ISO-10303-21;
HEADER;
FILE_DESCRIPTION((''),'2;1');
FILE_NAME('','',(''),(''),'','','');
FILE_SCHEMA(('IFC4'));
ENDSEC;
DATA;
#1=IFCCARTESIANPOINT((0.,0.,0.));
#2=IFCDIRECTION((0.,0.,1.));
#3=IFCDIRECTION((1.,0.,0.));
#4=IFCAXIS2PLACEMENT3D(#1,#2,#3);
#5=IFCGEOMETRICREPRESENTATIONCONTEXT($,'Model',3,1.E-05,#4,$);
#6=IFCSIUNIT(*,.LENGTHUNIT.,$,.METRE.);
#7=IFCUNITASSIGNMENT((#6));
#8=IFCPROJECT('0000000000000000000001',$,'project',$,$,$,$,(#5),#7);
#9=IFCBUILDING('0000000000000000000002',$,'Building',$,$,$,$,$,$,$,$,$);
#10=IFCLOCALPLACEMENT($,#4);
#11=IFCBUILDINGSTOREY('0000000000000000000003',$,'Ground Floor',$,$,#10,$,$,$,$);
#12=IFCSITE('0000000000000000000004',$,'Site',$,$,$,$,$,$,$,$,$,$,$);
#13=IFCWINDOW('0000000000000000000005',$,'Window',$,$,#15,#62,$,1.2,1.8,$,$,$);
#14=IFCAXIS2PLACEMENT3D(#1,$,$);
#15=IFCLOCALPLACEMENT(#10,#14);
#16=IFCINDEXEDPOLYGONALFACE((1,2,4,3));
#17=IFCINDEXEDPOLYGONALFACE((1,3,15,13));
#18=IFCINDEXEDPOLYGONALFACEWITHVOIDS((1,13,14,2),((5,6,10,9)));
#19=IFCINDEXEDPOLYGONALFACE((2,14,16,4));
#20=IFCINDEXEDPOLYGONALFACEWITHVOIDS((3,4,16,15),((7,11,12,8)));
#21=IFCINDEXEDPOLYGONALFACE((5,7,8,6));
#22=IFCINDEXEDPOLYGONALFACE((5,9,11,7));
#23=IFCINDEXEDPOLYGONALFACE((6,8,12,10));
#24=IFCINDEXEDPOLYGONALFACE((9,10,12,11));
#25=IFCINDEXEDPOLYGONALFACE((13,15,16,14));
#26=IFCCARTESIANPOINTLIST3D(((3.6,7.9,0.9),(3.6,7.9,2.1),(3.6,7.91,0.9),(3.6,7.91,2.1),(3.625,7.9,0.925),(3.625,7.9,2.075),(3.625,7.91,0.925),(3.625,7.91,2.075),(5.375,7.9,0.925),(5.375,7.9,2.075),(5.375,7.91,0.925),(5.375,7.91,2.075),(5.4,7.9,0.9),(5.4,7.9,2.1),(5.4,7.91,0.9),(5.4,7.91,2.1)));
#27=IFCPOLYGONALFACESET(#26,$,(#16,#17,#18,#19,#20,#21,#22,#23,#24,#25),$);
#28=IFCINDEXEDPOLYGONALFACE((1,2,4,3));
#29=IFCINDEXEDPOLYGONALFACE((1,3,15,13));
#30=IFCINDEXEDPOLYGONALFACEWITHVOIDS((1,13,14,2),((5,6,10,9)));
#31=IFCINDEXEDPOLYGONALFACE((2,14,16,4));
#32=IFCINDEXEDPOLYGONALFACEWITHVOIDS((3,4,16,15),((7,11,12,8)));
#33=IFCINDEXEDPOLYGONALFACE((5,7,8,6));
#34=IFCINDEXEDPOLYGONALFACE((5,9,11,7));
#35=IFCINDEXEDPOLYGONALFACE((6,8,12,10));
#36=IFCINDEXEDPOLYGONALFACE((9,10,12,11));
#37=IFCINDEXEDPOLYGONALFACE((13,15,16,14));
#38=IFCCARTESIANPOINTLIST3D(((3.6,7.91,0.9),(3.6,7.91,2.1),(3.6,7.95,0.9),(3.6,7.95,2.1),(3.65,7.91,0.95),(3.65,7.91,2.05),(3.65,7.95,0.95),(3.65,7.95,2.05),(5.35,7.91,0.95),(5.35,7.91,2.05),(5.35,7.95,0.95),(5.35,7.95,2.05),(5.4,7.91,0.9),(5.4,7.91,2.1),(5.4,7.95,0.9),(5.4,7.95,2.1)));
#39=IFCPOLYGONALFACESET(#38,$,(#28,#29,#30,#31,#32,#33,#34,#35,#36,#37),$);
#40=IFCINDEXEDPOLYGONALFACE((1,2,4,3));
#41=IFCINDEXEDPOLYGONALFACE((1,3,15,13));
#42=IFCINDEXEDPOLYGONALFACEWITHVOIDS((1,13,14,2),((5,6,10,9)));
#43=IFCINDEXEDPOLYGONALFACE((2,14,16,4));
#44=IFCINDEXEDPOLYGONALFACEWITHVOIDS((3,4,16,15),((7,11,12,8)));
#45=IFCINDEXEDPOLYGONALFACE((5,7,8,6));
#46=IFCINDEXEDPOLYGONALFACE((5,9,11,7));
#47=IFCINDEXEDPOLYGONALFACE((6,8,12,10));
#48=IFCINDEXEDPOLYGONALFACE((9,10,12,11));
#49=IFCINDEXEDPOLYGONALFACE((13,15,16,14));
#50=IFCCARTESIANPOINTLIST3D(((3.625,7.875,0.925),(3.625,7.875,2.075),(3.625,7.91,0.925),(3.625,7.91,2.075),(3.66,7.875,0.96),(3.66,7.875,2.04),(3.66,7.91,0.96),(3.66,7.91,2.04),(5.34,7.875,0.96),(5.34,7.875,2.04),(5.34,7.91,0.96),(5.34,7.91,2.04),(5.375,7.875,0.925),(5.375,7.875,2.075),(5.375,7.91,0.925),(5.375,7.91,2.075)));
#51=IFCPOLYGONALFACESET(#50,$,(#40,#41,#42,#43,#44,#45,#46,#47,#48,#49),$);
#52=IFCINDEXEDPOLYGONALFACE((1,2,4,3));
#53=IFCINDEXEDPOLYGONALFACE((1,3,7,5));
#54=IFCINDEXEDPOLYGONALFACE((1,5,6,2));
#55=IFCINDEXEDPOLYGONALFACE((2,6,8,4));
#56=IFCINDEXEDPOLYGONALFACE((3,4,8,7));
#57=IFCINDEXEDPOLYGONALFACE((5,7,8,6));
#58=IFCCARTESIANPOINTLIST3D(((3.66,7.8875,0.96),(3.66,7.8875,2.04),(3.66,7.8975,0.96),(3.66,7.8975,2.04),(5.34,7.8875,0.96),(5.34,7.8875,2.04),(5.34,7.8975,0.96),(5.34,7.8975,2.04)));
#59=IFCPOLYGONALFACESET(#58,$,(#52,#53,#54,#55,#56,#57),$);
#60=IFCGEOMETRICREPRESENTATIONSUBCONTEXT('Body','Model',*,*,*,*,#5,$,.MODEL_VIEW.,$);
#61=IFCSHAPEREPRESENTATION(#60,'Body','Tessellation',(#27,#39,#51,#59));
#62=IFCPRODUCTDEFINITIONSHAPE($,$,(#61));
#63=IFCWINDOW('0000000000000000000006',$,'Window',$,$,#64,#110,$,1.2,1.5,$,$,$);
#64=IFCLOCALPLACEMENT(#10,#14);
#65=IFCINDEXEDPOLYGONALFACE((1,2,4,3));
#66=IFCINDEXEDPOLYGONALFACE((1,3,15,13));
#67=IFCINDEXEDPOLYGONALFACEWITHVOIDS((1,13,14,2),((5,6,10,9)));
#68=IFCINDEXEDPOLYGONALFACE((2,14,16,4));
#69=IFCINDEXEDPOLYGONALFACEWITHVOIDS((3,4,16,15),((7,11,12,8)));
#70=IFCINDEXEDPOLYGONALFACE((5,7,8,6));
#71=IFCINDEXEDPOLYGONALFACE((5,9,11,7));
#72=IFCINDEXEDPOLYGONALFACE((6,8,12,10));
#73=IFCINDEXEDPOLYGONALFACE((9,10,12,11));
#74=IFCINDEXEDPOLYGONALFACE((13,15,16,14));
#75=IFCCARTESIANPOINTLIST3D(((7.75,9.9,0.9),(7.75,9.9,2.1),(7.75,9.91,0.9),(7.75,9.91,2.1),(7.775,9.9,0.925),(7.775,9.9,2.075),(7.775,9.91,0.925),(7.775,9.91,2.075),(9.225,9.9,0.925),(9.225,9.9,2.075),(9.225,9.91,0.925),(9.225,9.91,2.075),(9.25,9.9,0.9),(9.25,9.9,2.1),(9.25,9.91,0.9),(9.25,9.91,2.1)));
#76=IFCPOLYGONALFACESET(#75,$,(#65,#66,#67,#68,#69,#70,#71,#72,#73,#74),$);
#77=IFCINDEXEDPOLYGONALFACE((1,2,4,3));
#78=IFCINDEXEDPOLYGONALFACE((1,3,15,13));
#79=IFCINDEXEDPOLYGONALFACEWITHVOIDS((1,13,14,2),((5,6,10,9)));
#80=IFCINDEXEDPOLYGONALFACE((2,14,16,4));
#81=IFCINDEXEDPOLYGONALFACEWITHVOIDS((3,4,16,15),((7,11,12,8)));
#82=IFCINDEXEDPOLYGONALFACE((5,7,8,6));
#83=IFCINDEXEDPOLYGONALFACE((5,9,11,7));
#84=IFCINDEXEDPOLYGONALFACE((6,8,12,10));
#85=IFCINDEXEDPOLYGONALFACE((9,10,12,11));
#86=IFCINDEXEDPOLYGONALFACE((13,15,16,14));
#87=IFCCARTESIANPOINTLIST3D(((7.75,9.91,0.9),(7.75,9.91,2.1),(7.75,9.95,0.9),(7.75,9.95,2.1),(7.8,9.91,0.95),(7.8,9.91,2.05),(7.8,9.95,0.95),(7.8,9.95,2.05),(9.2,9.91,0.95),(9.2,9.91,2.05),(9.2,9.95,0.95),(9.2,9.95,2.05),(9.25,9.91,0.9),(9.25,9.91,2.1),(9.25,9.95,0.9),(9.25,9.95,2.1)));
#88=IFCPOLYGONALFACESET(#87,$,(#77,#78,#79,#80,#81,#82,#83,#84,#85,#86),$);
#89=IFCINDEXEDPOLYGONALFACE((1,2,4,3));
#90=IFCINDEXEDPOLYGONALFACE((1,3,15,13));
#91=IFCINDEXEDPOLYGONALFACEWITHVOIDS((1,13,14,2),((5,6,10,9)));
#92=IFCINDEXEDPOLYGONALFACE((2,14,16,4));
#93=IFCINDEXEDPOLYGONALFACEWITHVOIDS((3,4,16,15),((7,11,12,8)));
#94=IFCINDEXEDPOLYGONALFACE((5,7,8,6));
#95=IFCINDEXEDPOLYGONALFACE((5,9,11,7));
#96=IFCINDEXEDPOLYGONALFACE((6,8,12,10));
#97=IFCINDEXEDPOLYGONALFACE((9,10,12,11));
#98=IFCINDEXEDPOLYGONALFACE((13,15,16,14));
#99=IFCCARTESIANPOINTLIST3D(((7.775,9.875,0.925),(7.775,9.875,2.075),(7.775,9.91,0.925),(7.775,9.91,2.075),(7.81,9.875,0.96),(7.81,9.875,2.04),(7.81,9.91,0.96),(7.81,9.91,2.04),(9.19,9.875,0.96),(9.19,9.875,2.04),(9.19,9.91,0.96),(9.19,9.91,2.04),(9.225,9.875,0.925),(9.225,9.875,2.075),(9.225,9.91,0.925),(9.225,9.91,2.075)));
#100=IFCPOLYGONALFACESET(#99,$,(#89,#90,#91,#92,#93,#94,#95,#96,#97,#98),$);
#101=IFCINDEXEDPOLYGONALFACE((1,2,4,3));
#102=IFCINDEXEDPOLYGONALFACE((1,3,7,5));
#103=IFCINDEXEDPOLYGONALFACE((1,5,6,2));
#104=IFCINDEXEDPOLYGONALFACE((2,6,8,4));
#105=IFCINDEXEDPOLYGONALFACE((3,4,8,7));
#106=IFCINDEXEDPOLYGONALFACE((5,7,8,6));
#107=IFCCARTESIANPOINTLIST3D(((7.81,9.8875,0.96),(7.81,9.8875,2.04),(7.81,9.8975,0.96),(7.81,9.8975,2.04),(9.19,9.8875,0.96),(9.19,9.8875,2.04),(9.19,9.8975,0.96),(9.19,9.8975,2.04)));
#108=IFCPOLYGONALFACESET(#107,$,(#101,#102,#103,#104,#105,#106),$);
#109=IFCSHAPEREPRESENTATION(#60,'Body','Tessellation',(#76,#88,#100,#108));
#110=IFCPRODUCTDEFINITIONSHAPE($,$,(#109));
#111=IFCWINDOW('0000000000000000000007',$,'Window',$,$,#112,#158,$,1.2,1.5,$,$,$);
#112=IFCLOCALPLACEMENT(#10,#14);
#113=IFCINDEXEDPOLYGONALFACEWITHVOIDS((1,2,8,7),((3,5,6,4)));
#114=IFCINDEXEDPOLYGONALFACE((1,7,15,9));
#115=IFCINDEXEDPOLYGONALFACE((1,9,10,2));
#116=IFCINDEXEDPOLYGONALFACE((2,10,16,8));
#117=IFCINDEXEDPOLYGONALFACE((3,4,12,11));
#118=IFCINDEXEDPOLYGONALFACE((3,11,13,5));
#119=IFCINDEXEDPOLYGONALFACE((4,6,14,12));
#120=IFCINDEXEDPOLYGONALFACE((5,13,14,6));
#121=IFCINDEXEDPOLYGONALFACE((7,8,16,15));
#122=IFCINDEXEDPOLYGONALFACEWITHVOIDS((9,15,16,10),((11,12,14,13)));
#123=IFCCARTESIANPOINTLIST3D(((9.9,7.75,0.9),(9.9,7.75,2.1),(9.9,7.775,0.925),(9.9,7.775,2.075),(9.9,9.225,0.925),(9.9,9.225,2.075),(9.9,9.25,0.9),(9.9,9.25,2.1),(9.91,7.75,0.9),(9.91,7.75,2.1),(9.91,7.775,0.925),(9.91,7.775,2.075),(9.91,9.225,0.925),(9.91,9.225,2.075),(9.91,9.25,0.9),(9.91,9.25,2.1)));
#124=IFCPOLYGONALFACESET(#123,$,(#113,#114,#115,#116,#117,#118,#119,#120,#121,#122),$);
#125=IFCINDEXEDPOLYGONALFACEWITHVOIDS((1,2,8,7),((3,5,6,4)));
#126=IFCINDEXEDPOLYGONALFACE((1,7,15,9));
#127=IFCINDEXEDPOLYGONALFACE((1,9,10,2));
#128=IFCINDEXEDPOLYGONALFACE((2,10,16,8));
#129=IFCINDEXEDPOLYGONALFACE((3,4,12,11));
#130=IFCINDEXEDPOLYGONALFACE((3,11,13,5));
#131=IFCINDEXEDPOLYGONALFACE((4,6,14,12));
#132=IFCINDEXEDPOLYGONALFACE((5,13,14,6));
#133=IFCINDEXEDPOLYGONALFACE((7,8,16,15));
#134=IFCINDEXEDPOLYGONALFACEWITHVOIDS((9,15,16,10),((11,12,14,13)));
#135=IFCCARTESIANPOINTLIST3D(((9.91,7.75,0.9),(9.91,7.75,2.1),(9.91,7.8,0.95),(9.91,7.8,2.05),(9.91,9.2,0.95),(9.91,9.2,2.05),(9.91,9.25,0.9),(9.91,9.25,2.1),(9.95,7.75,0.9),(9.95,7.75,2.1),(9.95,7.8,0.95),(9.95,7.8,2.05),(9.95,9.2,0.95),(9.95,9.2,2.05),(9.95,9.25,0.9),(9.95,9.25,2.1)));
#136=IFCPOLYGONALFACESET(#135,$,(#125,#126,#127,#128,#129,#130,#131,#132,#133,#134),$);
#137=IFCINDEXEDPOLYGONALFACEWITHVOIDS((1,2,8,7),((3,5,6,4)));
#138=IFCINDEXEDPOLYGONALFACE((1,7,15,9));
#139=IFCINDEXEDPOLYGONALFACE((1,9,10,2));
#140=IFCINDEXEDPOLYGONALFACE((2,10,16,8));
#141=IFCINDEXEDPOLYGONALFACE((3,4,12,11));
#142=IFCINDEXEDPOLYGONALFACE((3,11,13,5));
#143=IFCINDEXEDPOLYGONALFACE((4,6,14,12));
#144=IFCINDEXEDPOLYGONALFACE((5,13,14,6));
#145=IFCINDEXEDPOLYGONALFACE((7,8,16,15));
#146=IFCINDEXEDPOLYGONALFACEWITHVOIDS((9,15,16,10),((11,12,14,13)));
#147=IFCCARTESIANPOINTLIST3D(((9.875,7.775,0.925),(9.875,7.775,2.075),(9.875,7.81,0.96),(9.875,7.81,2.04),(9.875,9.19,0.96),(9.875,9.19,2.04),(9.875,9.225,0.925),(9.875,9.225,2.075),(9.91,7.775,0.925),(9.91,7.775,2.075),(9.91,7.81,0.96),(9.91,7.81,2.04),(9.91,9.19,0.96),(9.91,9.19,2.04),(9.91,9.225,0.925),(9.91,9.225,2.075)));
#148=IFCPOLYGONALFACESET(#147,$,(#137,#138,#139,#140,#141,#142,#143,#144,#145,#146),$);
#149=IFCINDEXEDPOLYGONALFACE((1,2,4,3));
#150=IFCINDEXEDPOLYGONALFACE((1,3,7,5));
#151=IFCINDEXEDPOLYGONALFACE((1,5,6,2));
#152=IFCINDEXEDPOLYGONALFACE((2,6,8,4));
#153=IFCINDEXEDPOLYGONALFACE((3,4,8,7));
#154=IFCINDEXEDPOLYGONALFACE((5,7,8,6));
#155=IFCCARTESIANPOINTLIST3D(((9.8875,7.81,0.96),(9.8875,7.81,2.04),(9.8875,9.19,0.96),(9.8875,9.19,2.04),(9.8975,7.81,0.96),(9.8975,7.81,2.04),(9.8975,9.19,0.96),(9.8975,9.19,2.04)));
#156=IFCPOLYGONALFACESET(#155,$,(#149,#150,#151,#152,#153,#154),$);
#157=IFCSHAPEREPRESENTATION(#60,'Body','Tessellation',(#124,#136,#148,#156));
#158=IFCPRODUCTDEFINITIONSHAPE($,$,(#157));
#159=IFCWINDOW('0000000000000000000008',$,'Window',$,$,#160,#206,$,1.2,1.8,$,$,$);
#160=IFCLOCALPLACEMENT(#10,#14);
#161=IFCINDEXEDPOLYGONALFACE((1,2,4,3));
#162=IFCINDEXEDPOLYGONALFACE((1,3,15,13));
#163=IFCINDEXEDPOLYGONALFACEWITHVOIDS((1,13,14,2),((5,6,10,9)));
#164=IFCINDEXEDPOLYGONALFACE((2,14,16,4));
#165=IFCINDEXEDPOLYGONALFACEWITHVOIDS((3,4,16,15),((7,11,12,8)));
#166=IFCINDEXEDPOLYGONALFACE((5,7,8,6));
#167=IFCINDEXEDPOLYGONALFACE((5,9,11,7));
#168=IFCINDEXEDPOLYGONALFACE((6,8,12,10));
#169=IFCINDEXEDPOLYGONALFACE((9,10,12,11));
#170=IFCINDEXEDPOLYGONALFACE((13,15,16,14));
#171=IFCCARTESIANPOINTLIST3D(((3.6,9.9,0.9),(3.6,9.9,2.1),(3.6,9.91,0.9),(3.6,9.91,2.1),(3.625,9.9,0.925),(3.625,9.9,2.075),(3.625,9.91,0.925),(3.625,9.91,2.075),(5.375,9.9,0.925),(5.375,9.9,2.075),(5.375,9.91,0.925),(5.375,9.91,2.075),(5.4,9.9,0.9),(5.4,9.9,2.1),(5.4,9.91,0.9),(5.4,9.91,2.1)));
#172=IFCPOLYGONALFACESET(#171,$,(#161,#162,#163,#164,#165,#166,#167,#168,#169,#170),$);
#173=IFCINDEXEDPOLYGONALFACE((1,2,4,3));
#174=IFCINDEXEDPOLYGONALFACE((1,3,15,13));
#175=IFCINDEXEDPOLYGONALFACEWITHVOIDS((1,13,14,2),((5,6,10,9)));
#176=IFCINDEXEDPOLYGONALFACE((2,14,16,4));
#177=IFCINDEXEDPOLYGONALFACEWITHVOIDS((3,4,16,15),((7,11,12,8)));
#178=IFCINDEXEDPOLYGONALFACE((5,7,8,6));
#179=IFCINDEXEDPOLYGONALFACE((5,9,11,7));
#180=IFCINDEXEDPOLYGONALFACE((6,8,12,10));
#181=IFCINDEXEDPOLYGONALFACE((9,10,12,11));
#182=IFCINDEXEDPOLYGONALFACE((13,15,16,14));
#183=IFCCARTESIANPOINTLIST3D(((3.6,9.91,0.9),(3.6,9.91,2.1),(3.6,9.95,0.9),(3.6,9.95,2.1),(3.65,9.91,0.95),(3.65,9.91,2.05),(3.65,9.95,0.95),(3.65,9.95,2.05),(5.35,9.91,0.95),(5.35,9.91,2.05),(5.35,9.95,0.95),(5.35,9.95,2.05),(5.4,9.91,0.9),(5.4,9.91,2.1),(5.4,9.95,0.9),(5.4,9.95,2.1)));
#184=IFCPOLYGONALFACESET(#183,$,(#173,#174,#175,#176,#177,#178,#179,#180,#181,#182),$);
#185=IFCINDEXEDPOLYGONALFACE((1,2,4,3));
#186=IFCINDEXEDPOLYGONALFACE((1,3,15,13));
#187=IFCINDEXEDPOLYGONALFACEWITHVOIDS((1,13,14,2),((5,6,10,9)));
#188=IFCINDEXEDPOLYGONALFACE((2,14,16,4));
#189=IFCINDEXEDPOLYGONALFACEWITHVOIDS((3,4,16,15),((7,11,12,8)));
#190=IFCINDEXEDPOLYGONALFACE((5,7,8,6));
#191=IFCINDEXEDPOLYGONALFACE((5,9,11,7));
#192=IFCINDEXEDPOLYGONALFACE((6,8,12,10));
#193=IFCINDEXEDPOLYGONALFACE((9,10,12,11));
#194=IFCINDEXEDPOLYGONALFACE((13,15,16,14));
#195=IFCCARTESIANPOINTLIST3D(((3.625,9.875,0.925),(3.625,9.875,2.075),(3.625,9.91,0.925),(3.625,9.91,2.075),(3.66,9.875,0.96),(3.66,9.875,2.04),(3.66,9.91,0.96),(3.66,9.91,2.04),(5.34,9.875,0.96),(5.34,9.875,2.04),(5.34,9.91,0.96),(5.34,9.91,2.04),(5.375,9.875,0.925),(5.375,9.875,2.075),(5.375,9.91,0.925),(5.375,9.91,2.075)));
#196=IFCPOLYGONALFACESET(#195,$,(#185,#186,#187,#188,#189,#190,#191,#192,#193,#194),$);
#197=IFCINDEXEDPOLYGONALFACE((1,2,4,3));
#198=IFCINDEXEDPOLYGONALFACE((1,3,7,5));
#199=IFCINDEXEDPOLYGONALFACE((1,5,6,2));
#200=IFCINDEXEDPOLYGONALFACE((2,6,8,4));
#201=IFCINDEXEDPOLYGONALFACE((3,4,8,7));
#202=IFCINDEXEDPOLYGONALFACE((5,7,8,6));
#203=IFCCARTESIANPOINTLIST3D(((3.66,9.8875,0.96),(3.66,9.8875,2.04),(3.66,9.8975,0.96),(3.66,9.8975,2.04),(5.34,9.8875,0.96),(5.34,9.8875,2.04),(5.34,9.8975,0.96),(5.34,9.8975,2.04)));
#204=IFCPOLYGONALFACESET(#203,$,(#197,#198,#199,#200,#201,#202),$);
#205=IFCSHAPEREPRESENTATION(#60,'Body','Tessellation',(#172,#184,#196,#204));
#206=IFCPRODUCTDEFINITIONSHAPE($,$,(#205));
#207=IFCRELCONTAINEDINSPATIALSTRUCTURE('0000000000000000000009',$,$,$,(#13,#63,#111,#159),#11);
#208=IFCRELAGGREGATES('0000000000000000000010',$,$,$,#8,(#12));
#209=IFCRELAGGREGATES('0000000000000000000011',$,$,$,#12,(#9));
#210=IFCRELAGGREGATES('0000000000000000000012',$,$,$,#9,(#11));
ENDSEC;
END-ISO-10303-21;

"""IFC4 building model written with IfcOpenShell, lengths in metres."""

from ifc_helpers import new_model, si_unit, frame, origin_with_axes, place, context, subcontext, project, spatial, line, indexed_curve, outline, extrude, element, save


model = new_model("IFC4")

# Units and contexts
model_context = context("Model", 3, precision=1e-05, world=origin_with_axes())
body_context = subcontext(model_context, "Body", "Model", "MODEL_VIEW")
ifc_project = project(units=[si_unit("LENGTHUNIT", "METRE")], contexts=[model_context])

# Site, building, storey
site = spatial("IfcSite", under=ifc_project, Name="Site")
building = spatial("IfcBuilding", under=site, Name="Building")
storey_placement = place(None, origin_with_axes())
storey = spatial("IfcBuildingStorey", under=building, at=storey_placement, Name="Ground Floor")

# Windows
window_1_placement = place(storey_placement, frame((5.4, 8.0, 0.9), z_axis=(0.0, 0.0, 1.0), x_axis=(-1.0, 0.0, 0.0)))
element("IfcWindow", 1, at=window_1_placement, inside=storey, Name="Window", OverallHeight=1.2, OverallWidth=1.8, context=body_context, shape_type="SweptSolid", body=[
    extrude(outline(indexed_curve([(0.0, 0.0), (1.8, 0.0), (1.8, 1.2), (0.0, 1.2)], segments=[line(1, 2, 3, 4, 1)]), holes=[indexed_curve([(0.025, 0.025), (1.775, 0.025), (1.775, 1.175), (0.025, 1.175)], segments=[line(1, 2, 3, 4, 1)])]), frame((0.0, 0.09, 0.0), z_axis=(0.0, -1.0, 0.0), x_axis=(1.0, 0.0, 0.0)), (0.0, 0.0, -1.0), 0.01),
    extrude(outline(indexed_curve([(0.0, 0.0), (1.8, 0.0), (1.8, 1.2), (0.0, 1.2)], segments=[line(1, 2, 3, 4, 1)]), holes=[indexed_curve([(0.05, 0.05), (1.75, 0.05), (1.75, 1.15), (0.05, 1.15)], segments=[line(1, 2, 3, 4, 1)])]), frame((0.0, 0.05, 0.0), z_axis=(0.0, -1.0, 0.0), x_axis=(1.0, 0.0, 0.0)), (0.0, 0.0, -1.0), 0.04),
    extrude(outline(indexed_curve([(0.0, 0.0), (1.75, 0.0), (1.75, 1.15), (0.0, 1.15)], segments=[line(1, 2, 3, 4, 1)]), holes=[indexed_curve([(0.035, 0.035), (1.715, 0.035), (1.715, 1.115), (0.035, 1.115)], segments=[line(1, 2, 3, 4, 1)])]), frame((0.025, 0.09, 0.025), z_axis=(0.0, -1.0, 0.0), x_axis=(1.0, 0.0, 0.0)), (0.0, 0.0, -1.0), 0.035),
    extrude(outline(indexed_curve([(0.035, 0.035), (1.715, 0.035), (1.715, 1.115), (0.035, 1.115)], segments=[line(1, 2, 3, 4, 1)])), frame((0.025, 0.1025, 0.025), z_axis=(0.0, -1.0, 0.0), x_axis=(1.0, 0.0, 0.0)), (0.0, 0.0, -1.0), 0.01),
])
for number, where, z_axis, x_axis, name in (
    (2, (9.25, 10.0, 0.9), (0.0, 0.0, 1.0), (-1.0, 0.0, 0.0), "Window"),
    (3, (10.0, 7.75, 0.9), (0.0, 0.0, 1.0), (0.0, 1.0, 0.0), "Window"),
):
    element("IfcWindow", number, at=place(storey_placement, frame(where, z_axis=z_axis, x_axis=x_axis)), inside=storey, Name=name, OverallHeight=1.2, OverallWidth=1.5, context=body_context, shape_type="SweptSolid", body=[
        extrude(outline(indexed_curve([(0.0, 0.0), (1.5, 0.0), (1.5, 1.2), (0.0, 1.2)], segments=[line(1, 2, 3, 4, 1)]), holes=[indexed_curve([(0.025, 0.025), (1.475, 0.025), (1.475, 1.175), (0.025, 1.175)], segments=[line(1, 2, 3, 4, 1)])]), frame((0.0, 0.09, 0.0), z_axis=(0.0, -1.0, 0.0), x_axis=(1.0, 0.0, 0.0)), (0.0, 0.0, -1.0), 0.01),
        extrude(outline(indexed_curve([(0.0, 0.0), (1.5, 0.0), (1.5, 1.2), (0.0, 1.2)], segments=[line(1, 2, 3, 4, 1)]), holes=[indexed_curve([(0.05, 0.05), (1.45, 0.05), (1.45, 1.15), (0.05, 1.15)], segments=[line(1, 2, 3, 4, 1)])]), frame((0.0, 0.05, 0.0), z_axis=(0.0, -1.0, 0.0), x_axis=(1.0, 0.0, 0.0)), (0.0, 0.0, -1.0), 0.04),
        extrude(outline(indexed_curve([(0.0, 0.0), (1.45, 0.0), (1.45, 1.15), (0.0, 1.15)], segments=[line(1, 2, 3, 4, 1)]), holes=[indexed_curve([(0.035, 0.035), (1.415, 0.035), (1.415, 1.115), (0.035, 1.115)], segments=[line(1, 2, 3, 4, 1)])]), frame((0.025, 0.09, 0.025), z_axis=(0.0, -1.0, 0.0), x_axis=(1.0, 0.0, 0.0)), (0.0, 0.0, -1.0), 0.035),
        extrude(outline(indexed_curve([(0.035, 0.035), (1.415, 0.035), (1.415, 1.115), (0.035, 1.115)], segments=[line(1, 2, 3, 4, 1)])), frame((0.025, 0.1025, 0.025), z_axis=(0.0, -1.0, 0.0), x_axis=(1.0, 0.0, 0.0)), (0.0, 0.0, -1.0), 0.01),
    ])
window_2_placement = place(storey_placement, frame((5.4, 10.0, 0.9), z_axis=(0.0, 0.0, 1.0), x_axis=(-1.0, 0.0, 0.0)))
element("IfcWindow", 4, at=window_2_placement, inside=storey, Name="Window", OverallHeight=1.2, OverallWidth=1.8, context=body_context, shape_type="SweptSolid", body=[
    extrude(outline(indexed_curve([(0.0, 0.0), (1.8, 0.0), (1.8, 1.2), (0.0, 1.2)], segments=[line(1, 2, 3, 4, 1)]), holes=[indexed_curve([(0.025, 0.025), (1.775, 0.025), (1.775, 1.175), (0.025, 1.175)], segments=[line(1, 2, 3, 4, 1)])]), frame((0.0, 0.09, 0.0), z_axis=(0.0, -1.0, 0.0), x_axis=(1.0, 0.0, 0.0)), (0.0, 0.0, -1.0), 0.01),
    extrude(outline(indexed_curve([(0.0, 0.0), (1.8, 0.0), (1.8, 1.2), (0.0, 1.2)], segments=[line(1, 2, 3, 4, 1)]), holes=[indexed_curve([(0.05, 0.05), (1.75, 0.05), (1.75, 1.15), (0.05, 1.15)], segments=[line(1, 2, 3, 4, 1)])]), frame((0.0, 0.05, 0.0), z_axis=(0.0, -1.0, 0.0), x_axis=(1.0, 0.0, 0.0)), (0.0, 0.0, -1.0), 0.04),
    extrude(outline(indexed_curve([(0.0, 0.0), (1.75, 0.0), (1.75, 1.15), (0.0, 1.15)], segments=[line(1, 2, 3, 4, 1)]), holes=[indexed_curve([(0.035, 0.035), (1.715, 0.035), (1.715, 1.115), (0.035, 1.115)], segments=[line(1, 2, 3, 4, 1)])]), frame((0.025, 0.09, 0.025), z_axis=(0.0, -1.0, 0.0), x_axis=(1.0, 0.0, 0.0)), (0.0, 0.0, -1.0), 0.035),
    extrude(outline(indexed_curve([(0.035, 0.035), (1.715, 0.035), (1.715, 1.115), (0.035, 1.115)], segments=[line(1, 2, 3, 4, 1)])), frame((0.025, 0.1025, 0.025), z_axis=(0.0, -1.0, 0.0), x_axis=(1.0, 0.0, 0.0)), (0.0, 0.0, -1.0), 0.01),
])

save(model, "model.ifc")
